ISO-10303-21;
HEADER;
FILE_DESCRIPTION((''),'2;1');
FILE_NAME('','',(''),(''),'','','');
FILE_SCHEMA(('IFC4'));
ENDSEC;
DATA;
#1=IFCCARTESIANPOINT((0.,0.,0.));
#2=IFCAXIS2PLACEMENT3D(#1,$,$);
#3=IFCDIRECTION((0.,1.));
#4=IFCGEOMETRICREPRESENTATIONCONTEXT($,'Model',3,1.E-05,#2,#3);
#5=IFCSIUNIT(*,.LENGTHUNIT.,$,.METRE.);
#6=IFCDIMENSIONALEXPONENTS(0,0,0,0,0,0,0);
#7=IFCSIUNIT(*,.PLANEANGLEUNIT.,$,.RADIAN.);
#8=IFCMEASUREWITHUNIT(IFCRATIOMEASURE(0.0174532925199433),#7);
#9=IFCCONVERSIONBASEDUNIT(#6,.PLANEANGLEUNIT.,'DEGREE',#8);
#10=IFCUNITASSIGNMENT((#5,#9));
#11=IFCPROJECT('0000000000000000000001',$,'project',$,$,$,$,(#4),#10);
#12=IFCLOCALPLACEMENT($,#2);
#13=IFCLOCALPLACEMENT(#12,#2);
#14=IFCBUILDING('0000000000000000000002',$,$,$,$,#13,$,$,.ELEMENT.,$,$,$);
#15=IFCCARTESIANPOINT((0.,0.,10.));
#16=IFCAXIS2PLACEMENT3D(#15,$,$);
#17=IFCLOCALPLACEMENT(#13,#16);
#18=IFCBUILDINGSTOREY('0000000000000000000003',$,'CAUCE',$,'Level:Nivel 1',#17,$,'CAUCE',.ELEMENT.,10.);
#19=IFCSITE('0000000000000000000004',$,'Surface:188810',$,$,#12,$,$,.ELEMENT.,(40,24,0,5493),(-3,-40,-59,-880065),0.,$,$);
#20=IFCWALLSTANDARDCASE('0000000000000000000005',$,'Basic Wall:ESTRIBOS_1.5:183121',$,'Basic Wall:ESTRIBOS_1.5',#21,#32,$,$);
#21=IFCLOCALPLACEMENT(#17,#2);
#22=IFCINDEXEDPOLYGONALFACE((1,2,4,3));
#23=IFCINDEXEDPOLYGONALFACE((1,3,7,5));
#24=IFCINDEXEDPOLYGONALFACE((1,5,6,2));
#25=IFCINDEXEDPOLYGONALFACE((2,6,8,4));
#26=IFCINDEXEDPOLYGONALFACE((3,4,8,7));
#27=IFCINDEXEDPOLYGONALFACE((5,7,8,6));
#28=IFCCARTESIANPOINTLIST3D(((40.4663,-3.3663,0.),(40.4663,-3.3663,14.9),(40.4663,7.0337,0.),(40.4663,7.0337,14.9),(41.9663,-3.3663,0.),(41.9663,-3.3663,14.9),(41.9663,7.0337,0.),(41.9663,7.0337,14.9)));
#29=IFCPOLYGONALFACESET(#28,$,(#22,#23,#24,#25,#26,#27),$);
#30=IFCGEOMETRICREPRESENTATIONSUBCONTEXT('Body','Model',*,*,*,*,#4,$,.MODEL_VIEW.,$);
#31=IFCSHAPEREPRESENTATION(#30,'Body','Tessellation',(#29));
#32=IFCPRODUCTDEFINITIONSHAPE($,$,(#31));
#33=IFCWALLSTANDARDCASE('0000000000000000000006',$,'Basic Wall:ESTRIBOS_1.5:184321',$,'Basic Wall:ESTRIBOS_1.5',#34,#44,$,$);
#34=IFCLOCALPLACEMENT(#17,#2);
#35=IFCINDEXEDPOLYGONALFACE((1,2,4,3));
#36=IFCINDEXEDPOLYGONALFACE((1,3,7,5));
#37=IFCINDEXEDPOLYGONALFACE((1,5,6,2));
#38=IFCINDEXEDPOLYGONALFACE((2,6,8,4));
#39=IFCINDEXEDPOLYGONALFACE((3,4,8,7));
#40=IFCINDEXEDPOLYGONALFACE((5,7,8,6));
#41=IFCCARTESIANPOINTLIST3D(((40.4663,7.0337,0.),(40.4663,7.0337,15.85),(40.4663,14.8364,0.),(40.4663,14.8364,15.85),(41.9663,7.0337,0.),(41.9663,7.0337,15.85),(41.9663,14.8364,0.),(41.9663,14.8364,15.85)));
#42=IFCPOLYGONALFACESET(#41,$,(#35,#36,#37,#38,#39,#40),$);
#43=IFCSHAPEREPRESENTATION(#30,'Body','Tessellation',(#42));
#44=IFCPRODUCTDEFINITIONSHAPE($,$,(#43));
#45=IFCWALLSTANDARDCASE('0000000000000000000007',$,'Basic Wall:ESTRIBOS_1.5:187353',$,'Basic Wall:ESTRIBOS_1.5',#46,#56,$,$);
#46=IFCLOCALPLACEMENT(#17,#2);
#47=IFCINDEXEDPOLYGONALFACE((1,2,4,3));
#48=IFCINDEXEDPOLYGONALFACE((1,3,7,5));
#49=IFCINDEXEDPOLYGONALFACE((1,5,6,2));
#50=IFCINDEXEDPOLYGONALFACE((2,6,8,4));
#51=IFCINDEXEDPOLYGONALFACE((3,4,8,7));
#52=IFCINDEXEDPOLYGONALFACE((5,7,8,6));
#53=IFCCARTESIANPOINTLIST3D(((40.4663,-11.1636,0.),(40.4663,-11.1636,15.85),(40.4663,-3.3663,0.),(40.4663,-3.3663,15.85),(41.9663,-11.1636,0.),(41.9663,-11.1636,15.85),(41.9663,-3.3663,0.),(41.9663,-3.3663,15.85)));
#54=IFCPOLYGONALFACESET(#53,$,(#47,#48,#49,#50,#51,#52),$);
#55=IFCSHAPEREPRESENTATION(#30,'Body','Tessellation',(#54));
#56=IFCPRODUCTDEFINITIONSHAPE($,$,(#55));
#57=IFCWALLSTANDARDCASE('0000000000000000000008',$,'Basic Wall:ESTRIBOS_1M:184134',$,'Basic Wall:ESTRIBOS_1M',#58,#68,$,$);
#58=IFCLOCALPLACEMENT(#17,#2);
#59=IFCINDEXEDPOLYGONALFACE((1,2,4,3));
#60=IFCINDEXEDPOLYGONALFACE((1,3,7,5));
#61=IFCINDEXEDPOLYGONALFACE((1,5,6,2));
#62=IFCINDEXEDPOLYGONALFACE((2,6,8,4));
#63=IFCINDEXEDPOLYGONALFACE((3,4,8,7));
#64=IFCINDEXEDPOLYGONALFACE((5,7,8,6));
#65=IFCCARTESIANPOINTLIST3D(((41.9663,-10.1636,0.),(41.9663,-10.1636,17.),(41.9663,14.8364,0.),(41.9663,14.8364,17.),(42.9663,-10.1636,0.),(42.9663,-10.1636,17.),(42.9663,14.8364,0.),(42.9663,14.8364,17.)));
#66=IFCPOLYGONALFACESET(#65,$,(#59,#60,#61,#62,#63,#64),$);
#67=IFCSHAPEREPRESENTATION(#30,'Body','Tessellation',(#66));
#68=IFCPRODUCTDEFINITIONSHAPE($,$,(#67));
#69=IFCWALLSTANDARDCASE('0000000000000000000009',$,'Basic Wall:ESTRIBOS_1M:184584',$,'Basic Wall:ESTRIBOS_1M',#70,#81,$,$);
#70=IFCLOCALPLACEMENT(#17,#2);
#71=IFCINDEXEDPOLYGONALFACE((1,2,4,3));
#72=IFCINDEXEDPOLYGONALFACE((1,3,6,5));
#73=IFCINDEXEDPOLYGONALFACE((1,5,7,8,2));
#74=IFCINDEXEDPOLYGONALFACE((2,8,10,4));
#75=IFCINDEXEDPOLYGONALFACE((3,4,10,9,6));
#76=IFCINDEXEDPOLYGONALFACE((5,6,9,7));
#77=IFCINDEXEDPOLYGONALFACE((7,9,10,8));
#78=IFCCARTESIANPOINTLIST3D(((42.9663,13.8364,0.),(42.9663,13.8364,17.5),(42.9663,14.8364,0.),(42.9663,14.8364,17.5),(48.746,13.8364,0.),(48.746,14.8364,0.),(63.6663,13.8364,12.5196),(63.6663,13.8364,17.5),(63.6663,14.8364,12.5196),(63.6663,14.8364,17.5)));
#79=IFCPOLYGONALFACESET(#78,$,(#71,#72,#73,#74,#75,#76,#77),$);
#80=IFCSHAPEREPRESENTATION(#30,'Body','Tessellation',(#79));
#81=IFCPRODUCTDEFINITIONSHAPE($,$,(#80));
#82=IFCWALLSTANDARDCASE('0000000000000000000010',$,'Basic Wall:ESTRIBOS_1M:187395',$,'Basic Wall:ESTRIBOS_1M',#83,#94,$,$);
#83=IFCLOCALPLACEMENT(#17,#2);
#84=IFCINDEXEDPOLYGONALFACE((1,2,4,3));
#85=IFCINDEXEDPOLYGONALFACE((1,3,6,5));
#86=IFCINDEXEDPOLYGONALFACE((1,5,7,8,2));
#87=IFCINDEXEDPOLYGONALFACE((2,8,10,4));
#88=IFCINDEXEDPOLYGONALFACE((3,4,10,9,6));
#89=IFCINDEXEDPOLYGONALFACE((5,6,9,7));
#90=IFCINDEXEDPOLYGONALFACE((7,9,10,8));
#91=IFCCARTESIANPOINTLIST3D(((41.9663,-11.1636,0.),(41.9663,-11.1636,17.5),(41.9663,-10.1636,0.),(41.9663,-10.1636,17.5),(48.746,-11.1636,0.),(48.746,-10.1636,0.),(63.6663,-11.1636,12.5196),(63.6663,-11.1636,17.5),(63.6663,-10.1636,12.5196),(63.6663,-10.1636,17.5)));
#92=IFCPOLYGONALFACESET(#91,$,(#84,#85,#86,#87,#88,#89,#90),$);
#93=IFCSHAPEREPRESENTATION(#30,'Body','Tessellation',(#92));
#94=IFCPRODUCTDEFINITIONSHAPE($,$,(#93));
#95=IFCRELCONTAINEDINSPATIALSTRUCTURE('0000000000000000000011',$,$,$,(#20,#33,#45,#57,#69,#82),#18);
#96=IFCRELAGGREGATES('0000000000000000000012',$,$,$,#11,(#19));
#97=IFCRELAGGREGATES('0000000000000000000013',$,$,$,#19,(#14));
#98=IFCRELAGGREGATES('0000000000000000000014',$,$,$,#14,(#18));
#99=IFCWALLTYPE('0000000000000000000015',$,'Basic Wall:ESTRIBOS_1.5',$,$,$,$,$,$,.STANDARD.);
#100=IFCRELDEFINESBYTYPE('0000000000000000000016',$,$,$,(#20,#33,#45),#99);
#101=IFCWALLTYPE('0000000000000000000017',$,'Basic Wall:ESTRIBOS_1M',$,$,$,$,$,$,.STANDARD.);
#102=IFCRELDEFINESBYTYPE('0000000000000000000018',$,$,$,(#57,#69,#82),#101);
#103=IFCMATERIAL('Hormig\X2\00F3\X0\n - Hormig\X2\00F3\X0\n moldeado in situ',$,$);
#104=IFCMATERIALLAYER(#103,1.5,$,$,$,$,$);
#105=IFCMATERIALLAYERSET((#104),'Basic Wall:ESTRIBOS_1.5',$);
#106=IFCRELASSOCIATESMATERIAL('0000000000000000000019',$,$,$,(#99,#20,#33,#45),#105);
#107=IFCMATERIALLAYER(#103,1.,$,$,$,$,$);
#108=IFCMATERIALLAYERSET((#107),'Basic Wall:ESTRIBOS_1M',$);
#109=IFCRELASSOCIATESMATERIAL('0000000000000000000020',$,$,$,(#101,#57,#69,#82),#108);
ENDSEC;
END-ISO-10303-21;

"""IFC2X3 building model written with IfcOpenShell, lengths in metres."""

from ifc_helpers import new_model, entity, si_unit, converted_unit, direction, frame, frame_2d, origin, place, context, subcontext, project, spatial, rectangle, extrude, clip, halfspace, material, layer, layer_set, layer_usage, type_object, element, save


model = new_model("IFC2X3")

# Units and contexts
model_context = context("Model", 3, precision=1e-05, world=origin(), true_north=direction((0.0, 1.0)))
body_context = subcontext(model_context, "Body", "Model", "MODEL_VIEW")
ifc_project = project(units=[si_unit("LENGTHUNIT", "METRE"), converted_unit("PLANEANGLEUNIT", "DEGREE", entity("IfcRatioMeasure", 0.0174532925199433), si_unit("PLANEANGLEUNIT", "RADIAN"), dimensions=[0, 0, 0, 0, 0, 0, 0])], contexts=[model_context])

# Site, building, storey
site_placement = place(None, origin())
site = spatial("IfcSite", under=ifc_project, at=site_placement, Name="Surface:188810", CompositionType="ELEMENT", RefLatitude=(40, 24, 0, 5493), RefLongitude=(-3, -40, -59, -880065), RefElevation=0.0)
building_placement = place(site_placement, origin())
building = spatial("IfcBuilding", under=site, at=building_placement, CompositionType="ELEMENT")
storey_placement = place(building_placement, frame((0.0, 0.0, 10.0)))
storey = spatial("IfcBuildingStorey", under=building, at=storey_placement, Name="CAUCE", ObjectType="Level:Nivel 1", LongName="CAUCE", CompositionType="ELEMENT", Elevation=10.0)

# Shared definitions
ifc_material_1 = material(Name="Hormigón - Hormigón moldeado in situ")

# Walls
ifc_layer_1 = layer(ifc_material_1, 1.5)
ifc_layer_set_1 = layer_set([ifc_layer_1], Name="Basic Wall:ESTRIBOS_1.5")
ifc_layer_usage_1 = layer_usage(ifc_layer_set_1, "AXIS2", "NEGATIVE", 0.75)
wall_type_1 = type_object("IfcWallType", Name="Basic Wall:ESTRIBOS_1.5", PredefinedType="STANDARD", material=ifc_layer_set_1)
wall_1_placement = place(storey_placement, frame((41.2163, 7.0337, 0.0), z_axis=(0.0, 0.0, 1.0), x_axis=(0.0, -1.0, 0.0)))
element("IfcWallStandardCase", 1, at=wall_1_placement, inside=storey, type_object=wall_type_1, material=ifc_layer_usage_1, Name="Basic Wall:ESTRIBOS_1.5:183121", ObjectType="Basic Wall:ESTRIBOS_1.5", context=body_context, shape_type="SweptSolid", body=[
    extrude(rectangle(XDim=10.4, YDim=1.5, at=frame_2d((5.2, 0.0), x_axis=(-1.0, 0.0))), origin(), (0.0, 0.0, 1.0), 14.9),
])
ifc_layer_usage_2 = layer_usage(ifc_layer_set_1, "AXIS2", "NEGATIVE", 0.75)
wall_2_placement = place(storey_placement, frame((41.2163, 14.8364, 0.0), z_axis=(0.0, 0.0, 1.0), x_axis=(0.0, -1.0, 0.0)))
element("IfcWallStandardCase", 2, at=wall_2_placement, inside=storey, type_object=wall_type_1, material=ifc_layer_usage_2, Name="Basic Wall:ESTRIBOS_1.5:184321", ObjectType="Basic Wall:ESTRIBOS_1.5", context=body_context, shape_type="SweptSolid", body=[
    extrude(rectangle(XDim=7.8027, YDim=1.5, at=frame_2d((3.9014, 0.0), x_axis=(-1.0, 0.0))), origin(), (0.0, 0.0, 1.0), 15.85),
])
ifc_layer_usage_3 = layer_usage(ifc_layer_set_1, "AXIS2", "POSITIVE", -0.75)
wall_3_placement = place(storey_placement, frame((41.2163, -11.1636, 0.0), z_axis=(0.0, 0.0, 1.0), x_axis=(0.0, 1.0, 0.0)))
element("IfcWallStandardCase", 3, at=wall_3_placement, inside=storey, type_object=wall_type_1, material=ifc_layer_usage_3, Name="Basic Wall:ESTRIBOS_1.5:187353", ObjectType="Basic Wall:ESTRIBOS_1.5", context=body_context, shape_type="SweptSolid", body=[
    extrude(rectangle(XDim=7.7973, YDim=1.5, at=frame_2d((3.8986, 0.0), x_axis=(-1.0, 0.0))), origin(), (0.0, 0.0, 1.0), 15.85),
])
ifc_layer_2 = layer(ifc_material_1, 1.0)
ifc_layer_set_2 = layer_set([ifc_layer_2], Name="Basic Wall:ESTRIBOS_1M")
ifc_layer_usage_4 = layer_usage(ifc_layer_set_2, "AXIS2", "POSITIVE", -0.5)
wall_type_2 = type_object("IfcWallType", Name="Basic Wall:ESTRIBOS_1M", PredefinedType="STANDARD", material=ifc_layer_set_2)
wall_4_placement = place(storey_placement, frame((42.4663, 14.8364, 0.0), z_axis=(0.0, 0.0, 1.0), x_axis=(0.0, -1.0, 0.0)))
element("IfcWallStandardCase", 4, at=wall_4_placement, inside=storey, type_object=wall_type_2, material=ifc_layer_usage_4, Name="Basic Wall:ESTRIBOS_1M:184134", ObjectType="Basic Wall:ESTRIBOS_1M", context=body_context, shape_type="SweptSolid", body=[
    extrude(rectangle(XDim=25.0, YDim=1.0, at=frame_2d((12.5, 0.0), x_axis=(-1.0, 0.0))), origin(), (0.0, 0.0, 1.0), 17.0),
])
ifc_layer_usage_5 = layer_usage(ifc_layer_set_2, "AXIS2", "NEGATIVE", 0.5)
wall_5_placement = place(storey_placement, frame((42.9663, 14.3364, 0.0)))
element("IfcWallStandardCase", 5, at=wall_5_placement, inside=storey, type_object=wall_type_2, material=ifc_layer_usage_5, Name="Basic Wall:ESTRIBOS_1M:184584", ObjectType="Basic Wall:ESTRIBOS_1M", context=body_context, shape_type="Clipping", body=[
    clip(extrude(rectangle(XDim=20.7, YDim=1.0, at=frame_2d((10.35, 0.0), x_axis=(-1.0, 0.0))), origin(), (0.0, 0.0, 1.0), 17.5), halfspace(frame((20.7, -0.5, 12.5196), z_axis=(0.642788, 0.0, -0.766044), x_axis=(0.0, 1.0, 0.0)), False)),
])
ifc_layer_usage_6 = layer_usage(ifc_layer_set_2, "AXIS2", "POSITIVE", -0.5)
wall_6_placement = place(storey_placement, frame((41.9663, -10.6636, 0.0)))
element("IfcWallStandardCase", 6, at=wall_6_placement, inside=storey, type_object=wall_type_2, material=ifc_layer_usage_6, Name="Basic Wall:ESTRIBOS_1M:187395", ObjectType="Basic Wall:ESTRIBOS_1M", context=body_context, shape_type="Clipping", body=[
    clip(extrude(rectangle(XDim=21.7, YDim=1.0, at=frame_2d((10.85, 0.0), x_axis=(-1.0, 0.0))), origin(), (0.0, 0.0, 1.0), 17.5), halfspace(frame((21.7, -0.5, 12.5196), z_axis=(0.642788, 0.0, -0.766044), x_axis=(0.0, 1.0, 0.0)), False)),
])

save(model, "model.ifc")
